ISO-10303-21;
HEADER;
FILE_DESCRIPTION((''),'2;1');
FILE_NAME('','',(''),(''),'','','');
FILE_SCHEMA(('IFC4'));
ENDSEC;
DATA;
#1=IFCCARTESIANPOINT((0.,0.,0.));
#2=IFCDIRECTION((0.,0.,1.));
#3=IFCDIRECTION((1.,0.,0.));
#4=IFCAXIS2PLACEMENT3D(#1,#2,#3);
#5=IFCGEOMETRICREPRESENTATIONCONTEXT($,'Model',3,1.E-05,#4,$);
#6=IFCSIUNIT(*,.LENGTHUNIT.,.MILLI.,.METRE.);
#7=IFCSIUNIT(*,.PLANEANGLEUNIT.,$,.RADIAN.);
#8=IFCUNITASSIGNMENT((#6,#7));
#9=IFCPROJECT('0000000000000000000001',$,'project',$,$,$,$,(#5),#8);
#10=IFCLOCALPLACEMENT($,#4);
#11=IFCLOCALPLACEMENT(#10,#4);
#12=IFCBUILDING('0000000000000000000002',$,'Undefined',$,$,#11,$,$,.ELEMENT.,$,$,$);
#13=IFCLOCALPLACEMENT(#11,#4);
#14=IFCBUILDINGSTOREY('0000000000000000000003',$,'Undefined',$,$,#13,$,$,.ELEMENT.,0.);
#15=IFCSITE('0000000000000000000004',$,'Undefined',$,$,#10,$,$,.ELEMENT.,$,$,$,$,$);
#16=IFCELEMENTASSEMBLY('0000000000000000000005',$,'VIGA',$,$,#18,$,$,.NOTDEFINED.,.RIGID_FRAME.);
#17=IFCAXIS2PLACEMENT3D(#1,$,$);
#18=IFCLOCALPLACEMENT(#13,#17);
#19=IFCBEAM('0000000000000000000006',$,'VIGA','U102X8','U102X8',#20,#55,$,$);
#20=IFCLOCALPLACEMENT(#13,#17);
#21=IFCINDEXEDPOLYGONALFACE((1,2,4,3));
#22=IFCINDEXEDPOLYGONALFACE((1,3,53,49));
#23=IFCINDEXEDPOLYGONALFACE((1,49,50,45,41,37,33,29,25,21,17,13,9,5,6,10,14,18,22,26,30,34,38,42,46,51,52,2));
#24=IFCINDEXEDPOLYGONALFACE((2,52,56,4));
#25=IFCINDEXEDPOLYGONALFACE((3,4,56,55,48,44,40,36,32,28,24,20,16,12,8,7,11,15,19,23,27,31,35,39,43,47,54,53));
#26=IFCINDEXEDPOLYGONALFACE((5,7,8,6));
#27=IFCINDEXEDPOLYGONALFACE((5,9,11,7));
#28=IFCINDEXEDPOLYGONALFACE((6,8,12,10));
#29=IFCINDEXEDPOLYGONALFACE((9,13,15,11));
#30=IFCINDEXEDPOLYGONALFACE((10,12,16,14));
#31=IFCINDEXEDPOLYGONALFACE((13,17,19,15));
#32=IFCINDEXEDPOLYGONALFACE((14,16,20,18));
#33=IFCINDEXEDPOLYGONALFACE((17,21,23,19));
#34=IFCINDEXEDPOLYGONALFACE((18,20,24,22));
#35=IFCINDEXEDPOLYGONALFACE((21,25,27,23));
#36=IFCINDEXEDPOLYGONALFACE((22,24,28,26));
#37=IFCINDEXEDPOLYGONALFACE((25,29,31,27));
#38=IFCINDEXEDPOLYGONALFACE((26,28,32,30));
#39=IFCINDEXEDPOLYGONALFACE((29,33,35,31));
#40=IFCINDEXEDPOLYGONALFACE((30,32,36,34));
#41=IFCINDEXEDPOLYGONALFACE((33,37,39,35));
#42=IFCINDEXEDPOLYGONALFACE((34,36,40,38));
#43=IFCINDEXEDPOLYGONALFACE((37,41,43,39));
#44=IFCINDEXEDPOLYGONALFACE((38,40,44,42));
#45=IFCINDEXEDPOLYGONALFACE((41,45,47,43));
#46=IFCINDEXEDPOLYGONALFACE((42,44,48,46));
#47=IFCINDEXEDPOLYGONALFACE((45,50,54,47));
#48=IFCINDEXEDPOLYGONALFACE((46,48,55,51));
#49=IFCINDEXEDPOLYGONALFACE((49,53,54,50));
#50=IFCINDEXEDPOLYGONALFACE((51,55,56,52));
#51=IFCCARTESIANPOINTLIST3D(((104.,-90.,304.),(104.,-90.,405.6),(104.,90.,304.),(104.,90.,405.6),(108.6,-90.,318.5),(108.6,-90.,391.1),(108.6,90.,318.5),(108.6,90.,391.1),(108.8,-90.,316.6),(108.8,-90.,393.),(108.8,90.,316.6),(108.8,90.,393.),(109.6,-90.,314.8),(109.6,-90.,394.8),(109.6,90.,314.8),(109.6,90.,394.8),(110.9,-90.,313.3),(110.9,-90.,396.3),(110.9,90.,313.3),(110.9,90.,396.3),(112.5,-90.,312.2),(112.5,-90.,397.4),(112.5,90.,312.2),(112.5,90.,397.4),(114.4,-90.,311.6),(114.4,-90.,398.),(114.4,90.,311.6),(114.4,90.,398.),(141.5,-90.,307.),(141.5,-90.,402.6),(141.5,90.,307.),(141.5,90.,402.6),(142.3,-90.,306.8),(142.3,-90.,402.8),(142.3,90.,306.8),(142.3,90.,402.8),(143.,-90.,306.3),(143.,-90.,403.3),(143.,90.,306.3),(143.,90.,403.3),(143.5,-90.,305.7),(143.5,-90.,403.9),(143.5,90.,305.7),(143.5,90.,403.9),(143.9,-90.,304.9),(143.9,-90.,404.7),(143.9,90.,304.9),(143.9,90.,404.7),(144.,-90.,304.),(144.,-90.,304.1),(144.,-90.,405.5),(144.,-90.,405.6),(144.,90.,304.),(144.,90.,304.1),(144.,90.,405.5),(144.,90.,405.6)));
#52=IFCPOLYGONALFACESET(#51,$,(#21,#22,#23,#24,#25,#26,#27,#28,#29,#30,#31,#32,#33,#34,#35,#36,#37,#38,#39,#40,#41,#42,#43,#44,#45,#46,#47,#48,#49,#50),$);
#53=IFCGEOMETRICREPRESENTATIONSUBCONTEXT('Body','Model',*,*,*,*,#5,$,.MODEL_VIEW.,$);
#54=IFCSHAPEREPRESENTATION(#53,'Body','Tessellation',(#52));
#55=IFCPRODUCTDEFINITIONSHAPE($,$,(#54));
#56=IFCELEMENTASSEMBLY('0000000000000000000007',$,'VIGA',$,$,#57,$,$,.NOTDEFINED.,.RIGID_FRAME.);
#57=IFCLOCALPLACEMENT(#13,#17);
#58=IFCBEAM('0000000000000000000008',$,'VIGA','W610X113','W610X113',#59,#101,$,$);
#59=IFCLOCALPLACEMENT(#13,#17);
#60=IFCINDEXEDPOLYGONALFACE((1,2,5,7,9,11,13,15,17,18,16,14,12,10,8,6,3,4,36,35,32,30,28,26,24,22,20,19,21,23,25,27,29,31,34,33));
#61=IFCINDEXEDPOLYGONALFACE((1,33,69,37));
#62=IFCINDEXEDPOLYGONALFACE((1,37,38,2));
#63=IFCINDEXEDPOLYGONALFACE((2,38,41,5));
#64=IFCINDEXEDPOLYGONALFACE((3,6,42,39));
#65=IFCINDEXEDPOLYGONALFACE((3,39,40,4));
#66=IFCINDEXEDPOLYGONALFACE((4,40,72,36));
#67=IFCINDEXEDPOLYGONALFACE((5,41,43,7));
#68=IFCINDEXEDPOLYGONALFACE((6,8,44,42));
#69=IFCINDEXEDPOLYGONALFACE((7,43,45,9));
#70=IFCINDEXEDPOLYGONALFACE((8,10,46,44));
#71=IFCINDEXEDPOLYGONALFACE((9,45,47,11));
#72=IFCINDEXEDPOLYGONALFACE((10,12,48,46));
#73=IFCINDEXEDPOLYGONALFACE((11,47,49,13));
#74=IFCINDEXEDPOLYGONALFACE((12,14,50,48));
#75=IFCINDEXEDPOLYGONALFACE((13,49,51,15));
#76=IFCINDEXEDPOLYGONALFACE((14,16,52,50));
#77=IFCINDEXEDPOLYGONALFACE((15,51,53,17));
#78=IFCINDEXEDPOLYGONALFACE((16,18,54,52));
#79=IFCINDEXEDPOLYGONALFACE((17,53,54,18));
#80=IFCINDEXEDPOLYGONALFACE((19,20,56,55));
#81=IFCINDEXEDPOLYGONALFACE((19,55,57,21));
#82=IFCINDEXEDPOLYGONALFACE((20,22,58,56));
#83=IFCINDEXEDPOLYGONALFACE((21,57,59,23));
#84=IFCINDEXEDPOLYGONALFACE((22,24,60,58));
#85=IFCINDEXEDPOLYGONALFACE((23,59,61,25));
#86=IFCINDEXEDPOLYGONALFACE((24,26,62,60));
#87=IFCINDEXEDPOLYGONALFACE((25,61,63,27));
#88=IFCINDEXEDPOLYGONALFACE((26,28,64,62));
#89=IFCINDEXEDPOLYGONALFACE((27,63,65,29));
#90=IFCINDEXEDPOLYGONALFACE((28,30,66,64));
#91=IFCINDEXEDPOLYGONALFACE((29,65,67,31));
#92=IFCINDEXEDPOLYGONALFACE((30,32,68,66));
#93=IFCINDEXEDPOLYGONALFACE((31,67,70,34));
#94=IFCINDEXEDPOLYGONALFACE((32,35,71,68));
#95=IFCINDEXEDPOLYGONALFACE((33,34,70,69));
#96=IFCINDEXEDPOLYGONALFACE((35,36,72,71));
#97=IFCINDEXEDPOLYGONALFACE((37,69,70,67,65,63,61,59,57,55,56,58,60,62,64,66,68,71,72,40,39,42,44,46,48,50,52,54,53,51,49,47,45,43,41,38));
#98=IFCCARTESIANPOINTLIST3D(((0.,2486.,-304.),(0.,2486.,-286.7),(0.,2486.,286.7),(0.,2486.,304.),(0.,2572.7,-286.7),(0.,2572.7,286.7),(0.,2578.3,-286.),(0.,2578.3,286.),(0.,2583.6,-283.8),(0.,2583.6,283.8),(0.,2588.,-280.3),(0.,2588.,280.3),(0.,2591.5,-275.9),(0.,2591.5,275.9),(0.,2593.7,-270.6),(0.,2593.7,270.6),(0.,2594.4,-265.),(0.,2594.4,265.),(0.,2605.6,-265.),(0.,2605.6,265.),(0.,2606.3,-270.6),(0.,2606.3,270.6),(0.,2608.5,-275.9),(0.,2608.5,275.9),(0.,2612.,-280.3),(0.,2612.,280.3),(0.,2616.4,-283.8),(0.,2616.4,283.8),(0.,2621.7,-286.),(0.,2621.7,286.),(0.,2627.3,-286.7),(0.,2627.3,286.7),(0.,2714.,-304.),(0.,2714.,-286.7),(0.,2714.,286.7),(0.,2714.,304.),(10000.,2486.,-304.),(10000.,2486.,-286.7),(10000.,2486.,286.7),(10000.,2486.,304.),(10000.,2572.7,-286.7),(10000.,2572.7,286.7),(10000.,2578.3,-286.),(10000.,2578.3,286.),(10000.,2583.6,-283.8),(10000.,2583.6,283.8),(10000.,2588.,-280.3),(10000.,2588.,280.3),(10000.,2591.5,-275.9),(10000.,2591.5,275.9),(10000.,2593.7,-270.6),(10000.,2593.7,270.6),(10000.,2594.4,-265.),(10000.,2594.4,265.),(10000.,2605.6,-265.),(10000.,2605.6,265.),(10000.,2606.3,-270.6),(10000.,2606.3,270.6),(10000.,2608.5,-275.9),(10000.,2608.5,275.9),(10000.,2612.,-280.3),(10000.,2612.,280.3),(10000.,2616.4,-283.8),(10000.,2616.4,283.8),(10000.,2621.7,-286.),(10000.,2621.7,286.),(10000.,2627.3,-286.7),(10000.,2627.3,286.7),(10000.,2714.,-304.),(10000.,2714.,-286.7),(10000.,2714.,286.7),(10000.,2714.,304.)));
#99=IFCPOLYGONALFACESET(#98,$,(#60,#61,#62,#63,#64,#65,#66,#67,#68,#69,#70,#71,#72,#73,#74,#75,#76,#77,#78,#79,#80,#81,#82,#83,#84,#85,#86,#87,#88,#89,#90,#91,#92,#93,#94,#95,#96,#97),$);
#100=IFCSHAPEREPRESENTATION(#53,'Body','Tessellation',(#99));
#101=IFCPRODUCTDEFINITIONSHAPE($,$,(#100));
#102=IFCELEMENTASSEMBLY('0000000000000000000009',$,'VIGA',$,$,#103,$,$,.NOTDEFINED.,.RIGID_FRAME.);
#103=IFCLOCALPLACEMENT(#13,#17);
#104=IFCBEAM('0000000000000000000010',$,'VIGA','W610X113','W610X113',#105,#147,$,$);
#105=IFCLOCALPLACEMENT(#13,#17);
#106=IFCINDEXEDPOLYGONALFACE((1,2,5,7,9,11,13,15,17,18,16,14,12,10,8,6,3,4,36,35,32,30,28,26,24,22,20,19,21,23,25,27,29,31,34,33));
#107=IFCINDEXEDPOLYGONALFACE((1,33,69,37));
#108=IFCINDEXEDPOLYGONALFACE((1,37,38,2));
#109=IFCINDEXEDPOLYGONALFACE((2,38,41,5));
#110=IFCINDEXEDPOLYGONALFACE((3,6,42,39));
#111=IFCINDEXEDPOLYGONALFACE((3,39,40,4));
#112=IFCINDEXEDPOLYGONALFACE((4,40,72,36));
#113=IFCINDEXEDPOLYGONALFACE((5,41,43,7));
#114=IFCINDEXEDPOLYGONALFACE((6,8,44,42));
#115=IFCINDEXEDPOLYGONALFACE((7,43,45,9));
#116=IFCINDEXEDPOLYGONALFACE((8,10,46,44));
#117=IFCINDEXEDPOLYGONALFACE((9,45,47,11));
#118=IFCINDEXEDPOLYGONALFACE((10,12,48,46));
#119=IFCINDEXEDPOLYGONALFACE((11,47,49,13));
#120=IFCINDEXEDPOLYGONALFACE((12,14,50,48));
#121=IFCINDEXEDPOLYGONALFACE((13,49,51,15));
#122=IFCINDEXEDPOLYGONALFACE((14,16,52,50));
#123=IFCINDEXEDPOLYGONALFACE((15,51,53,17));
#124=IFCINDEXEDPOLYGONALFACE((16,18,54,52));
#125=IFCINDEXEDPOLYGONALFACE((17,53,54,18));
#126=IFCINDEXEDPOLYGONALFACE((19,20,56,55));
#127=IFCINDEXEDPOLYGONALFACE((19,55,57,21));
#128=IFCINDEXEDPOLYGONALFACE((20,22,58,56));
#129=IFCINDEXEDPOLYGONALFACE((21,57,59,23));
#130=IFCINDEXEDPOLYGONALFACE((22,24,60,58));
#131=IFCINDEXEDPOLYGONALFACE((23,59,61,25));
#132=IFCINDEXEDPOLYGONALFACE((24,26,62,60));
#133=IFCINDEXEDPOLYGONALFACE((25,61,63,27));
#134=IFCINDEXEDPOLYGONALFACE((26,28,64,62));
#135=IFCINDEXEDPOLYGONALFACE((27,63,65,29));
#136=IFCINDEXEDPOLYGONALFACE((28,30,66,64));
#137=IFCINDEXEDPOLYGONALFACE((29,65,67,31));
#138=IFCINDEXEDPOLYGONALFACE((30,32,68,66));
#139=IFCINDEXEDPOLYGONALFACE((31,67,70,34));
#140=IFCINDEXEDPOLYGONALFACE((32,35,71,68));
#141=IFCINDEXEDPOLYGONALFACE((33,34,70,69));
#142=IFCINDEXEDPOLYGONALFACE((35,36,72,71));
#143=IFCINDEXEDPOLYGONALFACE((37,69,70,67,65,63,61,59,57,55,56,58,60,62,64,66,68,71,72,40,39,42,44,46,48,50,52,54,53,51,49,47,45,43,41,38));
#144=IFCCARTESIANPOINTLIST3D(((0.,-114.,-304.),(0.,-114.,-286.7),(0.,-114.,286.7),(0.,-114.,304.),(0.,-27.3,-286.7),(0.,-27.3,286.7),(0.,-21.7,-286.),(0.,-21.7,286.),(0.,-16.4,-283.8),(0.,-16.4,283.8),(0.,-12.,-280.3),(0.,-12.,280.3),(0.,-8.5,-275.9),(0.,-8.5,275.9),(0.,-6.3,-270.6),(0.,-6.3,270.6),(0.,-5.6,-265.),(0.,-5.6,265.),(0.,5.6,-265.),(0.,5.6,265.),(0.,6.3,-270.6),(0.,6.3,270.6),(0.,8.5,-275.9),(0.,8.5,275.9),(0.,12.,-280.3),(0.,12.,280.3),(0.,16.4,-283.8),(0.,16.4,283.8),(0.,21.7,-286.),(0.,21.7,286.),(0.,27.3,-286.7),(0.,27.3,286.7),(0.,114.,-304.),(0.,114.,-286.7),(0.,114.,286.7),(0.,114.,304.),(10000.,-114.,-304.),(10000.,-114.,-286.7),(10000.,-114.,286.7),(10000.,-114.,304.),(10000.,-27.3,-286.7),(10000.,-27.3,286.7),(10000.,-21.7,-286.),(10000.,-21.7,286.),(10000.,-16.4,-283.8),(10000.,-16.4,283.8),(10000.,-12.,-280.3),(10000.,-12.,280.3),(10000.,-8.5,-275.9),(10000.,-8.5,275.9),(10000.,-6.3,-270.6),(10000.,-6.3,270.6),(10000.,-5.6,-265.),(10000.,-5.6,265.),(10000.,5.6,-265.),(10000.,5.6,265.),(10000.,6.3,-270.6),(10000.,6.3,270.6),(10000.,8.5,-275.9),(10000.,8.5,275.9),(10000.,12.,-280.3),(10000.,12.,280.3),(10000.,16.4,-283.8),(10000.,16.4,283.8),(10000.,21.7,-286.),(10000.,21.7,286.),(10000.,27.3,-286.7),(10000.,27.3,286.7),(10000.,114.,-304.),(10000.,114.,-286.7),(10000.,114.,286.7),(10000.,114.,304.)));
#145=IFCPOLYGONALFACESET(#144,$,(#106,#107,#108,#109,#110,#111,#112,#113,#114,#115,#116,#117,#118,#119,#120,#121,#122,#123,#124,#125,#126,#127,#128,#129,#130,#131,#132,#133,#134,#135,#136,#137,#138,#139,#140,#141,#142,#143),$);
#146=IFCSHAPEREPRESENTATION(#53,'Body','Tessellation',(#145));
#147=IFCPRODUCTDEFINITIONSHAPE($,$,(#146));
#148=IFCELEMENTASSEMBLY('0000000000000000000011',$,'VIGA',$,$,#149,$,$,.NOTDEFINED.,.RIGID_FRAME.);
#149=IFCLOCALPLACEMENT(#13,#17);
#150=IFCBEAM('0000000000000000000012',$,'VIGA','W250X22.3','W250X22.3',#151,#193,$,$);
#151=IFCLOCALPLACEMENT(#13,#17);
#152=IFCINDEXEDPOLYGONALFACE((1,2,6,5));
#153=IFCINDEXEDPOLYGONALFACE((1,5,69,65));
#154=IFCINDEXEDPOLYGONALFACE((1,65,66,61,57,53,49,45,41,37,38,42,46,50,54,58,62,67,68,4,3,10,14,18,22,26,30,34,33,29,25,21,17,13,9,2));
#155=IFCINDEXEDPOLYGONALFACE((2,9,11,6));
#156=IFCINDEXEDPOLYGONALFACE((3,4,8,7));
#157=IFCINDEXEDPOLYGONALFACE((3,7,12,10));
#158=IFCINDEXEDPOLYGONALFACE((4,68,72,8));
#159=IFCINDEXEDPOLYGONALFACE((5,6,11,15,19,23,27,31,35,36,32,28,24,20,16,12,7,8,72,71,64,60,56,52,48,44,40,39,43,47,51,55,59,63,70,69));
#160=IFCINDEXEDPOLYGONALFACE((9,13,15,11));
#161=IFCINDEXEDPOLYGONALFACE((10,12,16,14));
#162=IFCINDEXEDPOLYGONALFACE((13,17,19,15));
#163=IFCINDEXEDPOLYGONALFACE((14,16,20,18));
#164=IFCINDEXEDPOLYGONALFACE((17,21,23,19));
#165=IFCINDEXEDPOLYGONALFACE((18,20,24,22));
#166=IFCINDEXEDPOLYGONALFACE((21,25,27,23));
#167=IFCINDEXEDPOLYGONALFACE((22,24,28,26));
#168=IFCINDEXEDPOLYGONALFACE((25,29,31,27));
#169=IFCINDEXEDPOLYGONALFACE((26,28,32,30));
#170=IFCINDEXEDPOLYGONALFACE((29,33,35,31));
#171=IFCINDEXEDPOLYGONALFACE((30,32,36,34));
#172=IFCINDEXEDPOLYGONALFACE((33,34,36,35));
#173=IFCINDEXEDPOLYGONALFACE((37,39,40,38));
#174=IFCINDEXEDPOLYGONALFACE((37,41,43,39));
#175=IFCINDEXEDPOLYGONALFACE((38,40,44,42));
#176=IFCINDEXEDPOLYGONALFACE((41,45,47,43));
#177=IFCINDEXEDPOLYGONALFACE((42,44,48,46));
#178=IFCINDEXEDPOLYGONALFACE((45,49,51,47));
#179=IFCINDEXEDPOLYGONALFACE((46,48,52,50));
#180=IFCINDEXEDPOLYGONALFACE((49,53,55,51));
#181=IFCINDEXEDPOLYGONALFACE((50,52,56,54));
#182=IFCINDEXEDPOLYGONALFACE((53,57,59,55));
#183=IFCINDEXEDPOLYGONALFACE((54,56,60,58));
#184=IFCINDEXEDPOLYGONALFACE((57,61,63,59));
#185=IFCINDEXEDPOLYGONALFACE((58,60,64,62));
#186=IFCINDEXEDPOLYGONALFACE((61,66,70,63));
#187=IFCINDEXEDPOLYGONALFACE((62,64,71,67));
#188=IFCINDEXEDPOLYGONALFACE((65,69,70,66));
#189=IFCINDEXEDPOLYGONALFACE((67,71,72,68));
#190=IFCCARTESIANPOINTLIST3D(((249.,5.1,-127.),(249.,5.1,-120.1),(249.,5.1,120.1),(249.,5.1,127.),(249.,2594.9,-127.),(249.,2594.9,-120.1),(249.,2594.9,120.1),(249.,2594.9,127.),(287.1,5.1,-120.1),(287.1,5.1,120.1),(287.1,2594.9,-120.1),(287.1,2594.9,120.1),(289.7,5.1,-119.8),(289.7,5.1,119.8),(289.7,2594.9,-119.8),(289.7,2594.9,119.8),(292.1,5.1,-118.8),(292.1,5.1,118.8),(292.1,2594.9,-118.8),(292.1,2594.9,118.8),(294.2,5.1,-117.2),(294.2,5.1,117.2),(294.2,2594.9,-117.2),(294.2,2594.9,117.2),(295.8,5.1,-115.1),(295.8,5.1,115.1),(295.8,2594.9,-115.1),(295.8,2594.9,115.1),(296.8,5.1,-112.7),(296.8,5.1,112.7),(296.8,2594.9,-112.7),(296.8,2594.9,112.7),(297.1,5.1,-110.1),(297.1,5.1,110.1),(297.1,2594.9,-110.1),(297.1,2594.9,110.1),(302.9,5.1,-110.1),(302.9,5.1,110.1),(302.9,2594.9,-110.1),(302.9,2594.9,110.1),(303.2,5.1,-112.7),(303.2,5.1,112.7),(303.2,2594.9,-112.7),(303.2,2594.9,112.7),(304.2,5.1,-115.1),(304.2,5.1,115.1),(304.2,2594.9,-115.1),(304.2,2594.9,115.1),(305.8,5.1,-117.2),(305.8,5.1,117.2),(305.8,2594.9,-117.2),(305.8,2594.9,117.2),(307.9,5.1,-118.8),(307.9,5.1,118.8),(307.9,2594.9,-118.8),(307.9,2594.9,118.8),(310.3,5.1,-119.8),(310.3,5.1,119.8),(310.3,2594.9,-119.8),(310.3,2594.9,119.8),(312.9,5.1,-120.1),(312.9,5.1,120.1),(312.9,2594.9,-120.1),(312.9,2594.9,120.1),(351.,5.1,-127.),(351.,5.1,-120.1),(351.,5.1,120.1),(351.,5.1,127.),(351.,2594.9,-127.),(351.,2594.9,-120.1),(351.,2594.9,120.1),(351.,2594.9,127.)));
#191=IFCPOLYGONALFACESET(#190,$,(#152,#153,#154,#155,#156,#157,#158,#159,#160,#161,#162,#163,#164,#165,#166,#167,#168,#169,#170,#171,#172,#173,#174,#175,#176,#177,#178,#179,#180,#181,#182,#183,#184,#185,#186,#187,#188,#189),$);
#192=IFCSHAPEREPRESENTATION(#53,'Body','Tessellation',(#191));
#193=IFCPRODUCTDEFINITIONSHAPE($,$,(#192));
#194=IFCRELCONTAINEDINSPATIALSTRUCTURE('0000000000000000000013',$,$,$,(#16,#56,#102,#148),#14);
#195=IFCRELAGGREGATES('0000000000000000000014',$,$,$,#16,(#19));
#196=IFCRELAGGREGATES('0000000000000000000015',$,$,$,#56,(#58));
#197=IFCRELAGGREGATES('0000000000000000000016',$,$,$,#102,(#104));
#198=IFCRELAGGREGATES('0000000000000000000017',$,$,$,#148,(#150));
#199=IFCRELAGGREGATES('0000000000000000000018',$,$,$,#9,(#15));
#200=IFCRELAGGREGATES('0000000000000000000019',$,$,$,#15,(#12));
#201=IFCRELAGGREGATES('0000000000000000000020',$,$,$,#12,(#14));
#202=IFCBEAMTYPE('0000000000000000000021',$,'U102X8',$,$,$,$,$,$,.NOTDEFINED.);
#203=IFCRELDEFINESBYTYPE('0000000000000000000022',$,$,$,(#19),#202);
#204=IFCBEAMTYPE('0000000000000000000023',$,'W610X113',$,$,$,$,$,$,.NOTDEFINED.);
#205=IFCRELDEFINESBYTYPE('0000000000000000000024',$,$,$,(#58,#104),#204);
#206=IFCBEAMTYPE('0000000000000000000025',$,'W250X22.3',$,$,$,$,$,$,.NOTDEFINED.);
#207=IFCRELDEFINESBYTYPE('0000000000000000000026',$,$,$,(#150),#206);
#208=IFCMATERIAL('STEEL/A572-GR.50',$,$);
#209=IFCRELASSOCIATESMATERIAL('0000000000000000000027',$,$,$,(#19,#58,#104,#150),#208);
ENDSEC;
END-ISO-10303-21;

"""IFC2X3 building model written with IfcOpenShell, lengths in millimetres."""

from ifc_helpers import new_model, si_unit, frame, origin_with_axes, origin_2d_with_axis, place, context, subcontext, project, spatial, i_section, u_section, extrude, material, type_object, element, aggregate, save


model = new_model("IFC2X3")

# Units and contexts
model_context = context("Model", 3, precision=1e-05, world=origin_with_axes())
body_context = subcontext(model_context, "Body", "Model", "MODEL_VIEW")
ifc_project = project(units=[si_unit("LENGTHUNIT", "METRE", prefix="MILLI"), si_unit("PLANEANGLEUNIT", "RADIAN")], contexts=[model_context])

# Site, building, storey
site_placement = place(None, origin_with_axes())
site = spatial("IfcSite", under=ifc_project, at=site_placement, Name="Undefined", CompositionType="ELEMENT")
building_placement = place(site_placement, origin_with_axes())
building = spatial("IfcBuilding", under=site, at=building_placement, Name="Undefined", CompositionType="ELEMENT")
storey_placement = place(building_placement, origin_with_axes())
storey = spatial("IfcBuildingStorey", under=building, at=storey_placement, Name="Undefined", CompositionType="ELEMENT", Elevation=0.0)

# Element assemblies, beams
ifc_material_1 = material(Name="STEEL/A572-GR.50")
beam_type_1 = type_object("IfcBeamType", Name="U102X8", PredefinedType="NOTDEFINED")
assembly_1_placement = place(storey_placement, origin_with_axes())
assembly_1 = element("IfcElementAssembly", 1, at=assembly_1_placement, inside=storey, Name="VIGA", AssemblyPlace="NOTDEFINED", PredefinedType="RIGID_FRAME")
beam_1_placement = place(assembly_1_placement, frame((124.0, -90.0, 354.8), z_axis=(0.0, 0.0, 1.0), x_axis=(0.0, 1.0, 0.0)))
beam_1 = element("IfcBeam", 2, at=beam_1_placement, type_object=beam_type_1, material=ifc_material_1, Name="VIGA", Description="U102X8", ObjectType="U102X8", context=body_context, shape_type="SweptSolid", body=[
    extrude(u_section(Depth=101.6, FlangeWidth=40.0, WebThickness=4.6, FlangeThickness=6.0, FilletRadius=7.0, EdgeRadius=3.0, FlangeSlope=0.16839, at=origin_2d_with_axis()), frame((180.0, 0.0, 0.0), z_axis=(-1.0, 0.0, 0.0), x_axis=(0.0, -1.0, 0.0)), (0.0, 0.0, 1.0), 180.0),
])
aggregate(assembly_1, [beam_1])
assembly_2_placement = place(storey_placement, origin_with_axes())
assembly_2 = element("IfcElementAssembly", 3, at=assembly_2_placement, inside=storey, Name="VIGA", AssemblyPlace="NOTDEFINED", PredefinedType="RIGID_FRAME")
beam_type_2 = type_object("IfcBeamType", Name="W610X113", PredefinedType="NOTDEFINED")
beam_2_placement = place(assembly_2_placement, frame((0.0, 2600.0, 0.0), z_axis=(0.0, 0.0, 1.0), x_axis=(1.0, 0.0, 0.0)))
beam_2 = element("IfcBeam", 4, at=beam_2_placement, type_object=beam_type_2, material=ifc_material_1, Name="VIGA", Description="W610X113", ObjectType="W610X113", context=body_context, shape_type="SweptSolid", body=[
    extrude(i_section(OverallWidth=228.0, OverallDepth=608.0, WebThickness=11.2, FlangeThickness=17.3, FilletRadius=21.7, at=origin_2d_with_axis()), frame((10000.0, 0.0, 0.0), z_axis=(-1.0, 0.0, 0.0), x_axis=(0.0, -1.0, 0.0)), (0.0, 0.0, 1.0), 10000.0),
])
aggregate(assembly_2, [beam_2])
assembly_3_placement = place(storey_placement, origin_with_axes())
assembly_3 = element("IfcElementAssembly", 5, at=assembly_3_placement, inside=storey, Name="VIGA", AssemblyPlace="NOTDEFINED", PredefinedType="RIGID_FRAME")
beam_3_placement = place(assembly_3_placement, origin_with_axes())
beam_3 = element("IfcBeam", 6, at=beam_3_placement, type_object=beam_type_2, material=ifc_material_1, Name="VIGA", Description="W610X113", ObjectType="W610X113", context=body_context, shape_type="SweptSolid", body=[
    extrude(i_section(OverallWidth=228.0, OverallDepth=608.0, WebThickness=11.2, FlangeThickness=17.3, FilletRadius=21.7, at=origin_2d_with_axis()), frame((10000.0, 0.0, 0.0), z_axis=(-1.0, 0.0, 0.0), x_axis=(0.0, -1.0, 0.0)), (0.0, 0.0, 1.0), 10000.0),
])
aggregate(assembly_3, [beam_3])
assembly_4_placement = place(storey_placement, origin_with_axes())
assembly_4 = element("IfcElementAssembly", 7, at=assembly_4_placement, inside=storey, Name="VIGA", AssemblyPlace="NOTDEFINED", PredefinedType="RIGID_FRAME")
beam_type_3 = type_object("IfcBeamType", Name="W250X22.3", PredefinedType="NOTDEFINED")
beam_4_placement = place(assembly_4_placement, frame((300.0, 5.1, 0.0), z_axis=(0.0, 0.0, 1.0), x_axis=(0.0, 1.0, 0.0)))
beam_4 = element("IfcBeam", 8, at=beam_4_placement, type_object=beam_type_3, material=ifc_material_1, Name="VIGA", Description="W250X22.3", ObjectType="W250X22.3", context=body_context, shape_type="SweptSolid", body=[
    extrude(i_section(OverallWidth=102.0, OverallDepth=254.0, WebThickness=5.8, FlangeThickness=6.9, FilletRadius=10.0, at=origin_2d_with_axis()), frame((2589.8, 0.0, 0.0), z_axis=(-1.0, 0.0, 0.0), x_axis=(0.0, -1.0, 0.0)), (0.0, 0.0, 1.0), 2589.8),
])

aggregate(assembly_4, [beam_4])

save(model, "model.ifc")
